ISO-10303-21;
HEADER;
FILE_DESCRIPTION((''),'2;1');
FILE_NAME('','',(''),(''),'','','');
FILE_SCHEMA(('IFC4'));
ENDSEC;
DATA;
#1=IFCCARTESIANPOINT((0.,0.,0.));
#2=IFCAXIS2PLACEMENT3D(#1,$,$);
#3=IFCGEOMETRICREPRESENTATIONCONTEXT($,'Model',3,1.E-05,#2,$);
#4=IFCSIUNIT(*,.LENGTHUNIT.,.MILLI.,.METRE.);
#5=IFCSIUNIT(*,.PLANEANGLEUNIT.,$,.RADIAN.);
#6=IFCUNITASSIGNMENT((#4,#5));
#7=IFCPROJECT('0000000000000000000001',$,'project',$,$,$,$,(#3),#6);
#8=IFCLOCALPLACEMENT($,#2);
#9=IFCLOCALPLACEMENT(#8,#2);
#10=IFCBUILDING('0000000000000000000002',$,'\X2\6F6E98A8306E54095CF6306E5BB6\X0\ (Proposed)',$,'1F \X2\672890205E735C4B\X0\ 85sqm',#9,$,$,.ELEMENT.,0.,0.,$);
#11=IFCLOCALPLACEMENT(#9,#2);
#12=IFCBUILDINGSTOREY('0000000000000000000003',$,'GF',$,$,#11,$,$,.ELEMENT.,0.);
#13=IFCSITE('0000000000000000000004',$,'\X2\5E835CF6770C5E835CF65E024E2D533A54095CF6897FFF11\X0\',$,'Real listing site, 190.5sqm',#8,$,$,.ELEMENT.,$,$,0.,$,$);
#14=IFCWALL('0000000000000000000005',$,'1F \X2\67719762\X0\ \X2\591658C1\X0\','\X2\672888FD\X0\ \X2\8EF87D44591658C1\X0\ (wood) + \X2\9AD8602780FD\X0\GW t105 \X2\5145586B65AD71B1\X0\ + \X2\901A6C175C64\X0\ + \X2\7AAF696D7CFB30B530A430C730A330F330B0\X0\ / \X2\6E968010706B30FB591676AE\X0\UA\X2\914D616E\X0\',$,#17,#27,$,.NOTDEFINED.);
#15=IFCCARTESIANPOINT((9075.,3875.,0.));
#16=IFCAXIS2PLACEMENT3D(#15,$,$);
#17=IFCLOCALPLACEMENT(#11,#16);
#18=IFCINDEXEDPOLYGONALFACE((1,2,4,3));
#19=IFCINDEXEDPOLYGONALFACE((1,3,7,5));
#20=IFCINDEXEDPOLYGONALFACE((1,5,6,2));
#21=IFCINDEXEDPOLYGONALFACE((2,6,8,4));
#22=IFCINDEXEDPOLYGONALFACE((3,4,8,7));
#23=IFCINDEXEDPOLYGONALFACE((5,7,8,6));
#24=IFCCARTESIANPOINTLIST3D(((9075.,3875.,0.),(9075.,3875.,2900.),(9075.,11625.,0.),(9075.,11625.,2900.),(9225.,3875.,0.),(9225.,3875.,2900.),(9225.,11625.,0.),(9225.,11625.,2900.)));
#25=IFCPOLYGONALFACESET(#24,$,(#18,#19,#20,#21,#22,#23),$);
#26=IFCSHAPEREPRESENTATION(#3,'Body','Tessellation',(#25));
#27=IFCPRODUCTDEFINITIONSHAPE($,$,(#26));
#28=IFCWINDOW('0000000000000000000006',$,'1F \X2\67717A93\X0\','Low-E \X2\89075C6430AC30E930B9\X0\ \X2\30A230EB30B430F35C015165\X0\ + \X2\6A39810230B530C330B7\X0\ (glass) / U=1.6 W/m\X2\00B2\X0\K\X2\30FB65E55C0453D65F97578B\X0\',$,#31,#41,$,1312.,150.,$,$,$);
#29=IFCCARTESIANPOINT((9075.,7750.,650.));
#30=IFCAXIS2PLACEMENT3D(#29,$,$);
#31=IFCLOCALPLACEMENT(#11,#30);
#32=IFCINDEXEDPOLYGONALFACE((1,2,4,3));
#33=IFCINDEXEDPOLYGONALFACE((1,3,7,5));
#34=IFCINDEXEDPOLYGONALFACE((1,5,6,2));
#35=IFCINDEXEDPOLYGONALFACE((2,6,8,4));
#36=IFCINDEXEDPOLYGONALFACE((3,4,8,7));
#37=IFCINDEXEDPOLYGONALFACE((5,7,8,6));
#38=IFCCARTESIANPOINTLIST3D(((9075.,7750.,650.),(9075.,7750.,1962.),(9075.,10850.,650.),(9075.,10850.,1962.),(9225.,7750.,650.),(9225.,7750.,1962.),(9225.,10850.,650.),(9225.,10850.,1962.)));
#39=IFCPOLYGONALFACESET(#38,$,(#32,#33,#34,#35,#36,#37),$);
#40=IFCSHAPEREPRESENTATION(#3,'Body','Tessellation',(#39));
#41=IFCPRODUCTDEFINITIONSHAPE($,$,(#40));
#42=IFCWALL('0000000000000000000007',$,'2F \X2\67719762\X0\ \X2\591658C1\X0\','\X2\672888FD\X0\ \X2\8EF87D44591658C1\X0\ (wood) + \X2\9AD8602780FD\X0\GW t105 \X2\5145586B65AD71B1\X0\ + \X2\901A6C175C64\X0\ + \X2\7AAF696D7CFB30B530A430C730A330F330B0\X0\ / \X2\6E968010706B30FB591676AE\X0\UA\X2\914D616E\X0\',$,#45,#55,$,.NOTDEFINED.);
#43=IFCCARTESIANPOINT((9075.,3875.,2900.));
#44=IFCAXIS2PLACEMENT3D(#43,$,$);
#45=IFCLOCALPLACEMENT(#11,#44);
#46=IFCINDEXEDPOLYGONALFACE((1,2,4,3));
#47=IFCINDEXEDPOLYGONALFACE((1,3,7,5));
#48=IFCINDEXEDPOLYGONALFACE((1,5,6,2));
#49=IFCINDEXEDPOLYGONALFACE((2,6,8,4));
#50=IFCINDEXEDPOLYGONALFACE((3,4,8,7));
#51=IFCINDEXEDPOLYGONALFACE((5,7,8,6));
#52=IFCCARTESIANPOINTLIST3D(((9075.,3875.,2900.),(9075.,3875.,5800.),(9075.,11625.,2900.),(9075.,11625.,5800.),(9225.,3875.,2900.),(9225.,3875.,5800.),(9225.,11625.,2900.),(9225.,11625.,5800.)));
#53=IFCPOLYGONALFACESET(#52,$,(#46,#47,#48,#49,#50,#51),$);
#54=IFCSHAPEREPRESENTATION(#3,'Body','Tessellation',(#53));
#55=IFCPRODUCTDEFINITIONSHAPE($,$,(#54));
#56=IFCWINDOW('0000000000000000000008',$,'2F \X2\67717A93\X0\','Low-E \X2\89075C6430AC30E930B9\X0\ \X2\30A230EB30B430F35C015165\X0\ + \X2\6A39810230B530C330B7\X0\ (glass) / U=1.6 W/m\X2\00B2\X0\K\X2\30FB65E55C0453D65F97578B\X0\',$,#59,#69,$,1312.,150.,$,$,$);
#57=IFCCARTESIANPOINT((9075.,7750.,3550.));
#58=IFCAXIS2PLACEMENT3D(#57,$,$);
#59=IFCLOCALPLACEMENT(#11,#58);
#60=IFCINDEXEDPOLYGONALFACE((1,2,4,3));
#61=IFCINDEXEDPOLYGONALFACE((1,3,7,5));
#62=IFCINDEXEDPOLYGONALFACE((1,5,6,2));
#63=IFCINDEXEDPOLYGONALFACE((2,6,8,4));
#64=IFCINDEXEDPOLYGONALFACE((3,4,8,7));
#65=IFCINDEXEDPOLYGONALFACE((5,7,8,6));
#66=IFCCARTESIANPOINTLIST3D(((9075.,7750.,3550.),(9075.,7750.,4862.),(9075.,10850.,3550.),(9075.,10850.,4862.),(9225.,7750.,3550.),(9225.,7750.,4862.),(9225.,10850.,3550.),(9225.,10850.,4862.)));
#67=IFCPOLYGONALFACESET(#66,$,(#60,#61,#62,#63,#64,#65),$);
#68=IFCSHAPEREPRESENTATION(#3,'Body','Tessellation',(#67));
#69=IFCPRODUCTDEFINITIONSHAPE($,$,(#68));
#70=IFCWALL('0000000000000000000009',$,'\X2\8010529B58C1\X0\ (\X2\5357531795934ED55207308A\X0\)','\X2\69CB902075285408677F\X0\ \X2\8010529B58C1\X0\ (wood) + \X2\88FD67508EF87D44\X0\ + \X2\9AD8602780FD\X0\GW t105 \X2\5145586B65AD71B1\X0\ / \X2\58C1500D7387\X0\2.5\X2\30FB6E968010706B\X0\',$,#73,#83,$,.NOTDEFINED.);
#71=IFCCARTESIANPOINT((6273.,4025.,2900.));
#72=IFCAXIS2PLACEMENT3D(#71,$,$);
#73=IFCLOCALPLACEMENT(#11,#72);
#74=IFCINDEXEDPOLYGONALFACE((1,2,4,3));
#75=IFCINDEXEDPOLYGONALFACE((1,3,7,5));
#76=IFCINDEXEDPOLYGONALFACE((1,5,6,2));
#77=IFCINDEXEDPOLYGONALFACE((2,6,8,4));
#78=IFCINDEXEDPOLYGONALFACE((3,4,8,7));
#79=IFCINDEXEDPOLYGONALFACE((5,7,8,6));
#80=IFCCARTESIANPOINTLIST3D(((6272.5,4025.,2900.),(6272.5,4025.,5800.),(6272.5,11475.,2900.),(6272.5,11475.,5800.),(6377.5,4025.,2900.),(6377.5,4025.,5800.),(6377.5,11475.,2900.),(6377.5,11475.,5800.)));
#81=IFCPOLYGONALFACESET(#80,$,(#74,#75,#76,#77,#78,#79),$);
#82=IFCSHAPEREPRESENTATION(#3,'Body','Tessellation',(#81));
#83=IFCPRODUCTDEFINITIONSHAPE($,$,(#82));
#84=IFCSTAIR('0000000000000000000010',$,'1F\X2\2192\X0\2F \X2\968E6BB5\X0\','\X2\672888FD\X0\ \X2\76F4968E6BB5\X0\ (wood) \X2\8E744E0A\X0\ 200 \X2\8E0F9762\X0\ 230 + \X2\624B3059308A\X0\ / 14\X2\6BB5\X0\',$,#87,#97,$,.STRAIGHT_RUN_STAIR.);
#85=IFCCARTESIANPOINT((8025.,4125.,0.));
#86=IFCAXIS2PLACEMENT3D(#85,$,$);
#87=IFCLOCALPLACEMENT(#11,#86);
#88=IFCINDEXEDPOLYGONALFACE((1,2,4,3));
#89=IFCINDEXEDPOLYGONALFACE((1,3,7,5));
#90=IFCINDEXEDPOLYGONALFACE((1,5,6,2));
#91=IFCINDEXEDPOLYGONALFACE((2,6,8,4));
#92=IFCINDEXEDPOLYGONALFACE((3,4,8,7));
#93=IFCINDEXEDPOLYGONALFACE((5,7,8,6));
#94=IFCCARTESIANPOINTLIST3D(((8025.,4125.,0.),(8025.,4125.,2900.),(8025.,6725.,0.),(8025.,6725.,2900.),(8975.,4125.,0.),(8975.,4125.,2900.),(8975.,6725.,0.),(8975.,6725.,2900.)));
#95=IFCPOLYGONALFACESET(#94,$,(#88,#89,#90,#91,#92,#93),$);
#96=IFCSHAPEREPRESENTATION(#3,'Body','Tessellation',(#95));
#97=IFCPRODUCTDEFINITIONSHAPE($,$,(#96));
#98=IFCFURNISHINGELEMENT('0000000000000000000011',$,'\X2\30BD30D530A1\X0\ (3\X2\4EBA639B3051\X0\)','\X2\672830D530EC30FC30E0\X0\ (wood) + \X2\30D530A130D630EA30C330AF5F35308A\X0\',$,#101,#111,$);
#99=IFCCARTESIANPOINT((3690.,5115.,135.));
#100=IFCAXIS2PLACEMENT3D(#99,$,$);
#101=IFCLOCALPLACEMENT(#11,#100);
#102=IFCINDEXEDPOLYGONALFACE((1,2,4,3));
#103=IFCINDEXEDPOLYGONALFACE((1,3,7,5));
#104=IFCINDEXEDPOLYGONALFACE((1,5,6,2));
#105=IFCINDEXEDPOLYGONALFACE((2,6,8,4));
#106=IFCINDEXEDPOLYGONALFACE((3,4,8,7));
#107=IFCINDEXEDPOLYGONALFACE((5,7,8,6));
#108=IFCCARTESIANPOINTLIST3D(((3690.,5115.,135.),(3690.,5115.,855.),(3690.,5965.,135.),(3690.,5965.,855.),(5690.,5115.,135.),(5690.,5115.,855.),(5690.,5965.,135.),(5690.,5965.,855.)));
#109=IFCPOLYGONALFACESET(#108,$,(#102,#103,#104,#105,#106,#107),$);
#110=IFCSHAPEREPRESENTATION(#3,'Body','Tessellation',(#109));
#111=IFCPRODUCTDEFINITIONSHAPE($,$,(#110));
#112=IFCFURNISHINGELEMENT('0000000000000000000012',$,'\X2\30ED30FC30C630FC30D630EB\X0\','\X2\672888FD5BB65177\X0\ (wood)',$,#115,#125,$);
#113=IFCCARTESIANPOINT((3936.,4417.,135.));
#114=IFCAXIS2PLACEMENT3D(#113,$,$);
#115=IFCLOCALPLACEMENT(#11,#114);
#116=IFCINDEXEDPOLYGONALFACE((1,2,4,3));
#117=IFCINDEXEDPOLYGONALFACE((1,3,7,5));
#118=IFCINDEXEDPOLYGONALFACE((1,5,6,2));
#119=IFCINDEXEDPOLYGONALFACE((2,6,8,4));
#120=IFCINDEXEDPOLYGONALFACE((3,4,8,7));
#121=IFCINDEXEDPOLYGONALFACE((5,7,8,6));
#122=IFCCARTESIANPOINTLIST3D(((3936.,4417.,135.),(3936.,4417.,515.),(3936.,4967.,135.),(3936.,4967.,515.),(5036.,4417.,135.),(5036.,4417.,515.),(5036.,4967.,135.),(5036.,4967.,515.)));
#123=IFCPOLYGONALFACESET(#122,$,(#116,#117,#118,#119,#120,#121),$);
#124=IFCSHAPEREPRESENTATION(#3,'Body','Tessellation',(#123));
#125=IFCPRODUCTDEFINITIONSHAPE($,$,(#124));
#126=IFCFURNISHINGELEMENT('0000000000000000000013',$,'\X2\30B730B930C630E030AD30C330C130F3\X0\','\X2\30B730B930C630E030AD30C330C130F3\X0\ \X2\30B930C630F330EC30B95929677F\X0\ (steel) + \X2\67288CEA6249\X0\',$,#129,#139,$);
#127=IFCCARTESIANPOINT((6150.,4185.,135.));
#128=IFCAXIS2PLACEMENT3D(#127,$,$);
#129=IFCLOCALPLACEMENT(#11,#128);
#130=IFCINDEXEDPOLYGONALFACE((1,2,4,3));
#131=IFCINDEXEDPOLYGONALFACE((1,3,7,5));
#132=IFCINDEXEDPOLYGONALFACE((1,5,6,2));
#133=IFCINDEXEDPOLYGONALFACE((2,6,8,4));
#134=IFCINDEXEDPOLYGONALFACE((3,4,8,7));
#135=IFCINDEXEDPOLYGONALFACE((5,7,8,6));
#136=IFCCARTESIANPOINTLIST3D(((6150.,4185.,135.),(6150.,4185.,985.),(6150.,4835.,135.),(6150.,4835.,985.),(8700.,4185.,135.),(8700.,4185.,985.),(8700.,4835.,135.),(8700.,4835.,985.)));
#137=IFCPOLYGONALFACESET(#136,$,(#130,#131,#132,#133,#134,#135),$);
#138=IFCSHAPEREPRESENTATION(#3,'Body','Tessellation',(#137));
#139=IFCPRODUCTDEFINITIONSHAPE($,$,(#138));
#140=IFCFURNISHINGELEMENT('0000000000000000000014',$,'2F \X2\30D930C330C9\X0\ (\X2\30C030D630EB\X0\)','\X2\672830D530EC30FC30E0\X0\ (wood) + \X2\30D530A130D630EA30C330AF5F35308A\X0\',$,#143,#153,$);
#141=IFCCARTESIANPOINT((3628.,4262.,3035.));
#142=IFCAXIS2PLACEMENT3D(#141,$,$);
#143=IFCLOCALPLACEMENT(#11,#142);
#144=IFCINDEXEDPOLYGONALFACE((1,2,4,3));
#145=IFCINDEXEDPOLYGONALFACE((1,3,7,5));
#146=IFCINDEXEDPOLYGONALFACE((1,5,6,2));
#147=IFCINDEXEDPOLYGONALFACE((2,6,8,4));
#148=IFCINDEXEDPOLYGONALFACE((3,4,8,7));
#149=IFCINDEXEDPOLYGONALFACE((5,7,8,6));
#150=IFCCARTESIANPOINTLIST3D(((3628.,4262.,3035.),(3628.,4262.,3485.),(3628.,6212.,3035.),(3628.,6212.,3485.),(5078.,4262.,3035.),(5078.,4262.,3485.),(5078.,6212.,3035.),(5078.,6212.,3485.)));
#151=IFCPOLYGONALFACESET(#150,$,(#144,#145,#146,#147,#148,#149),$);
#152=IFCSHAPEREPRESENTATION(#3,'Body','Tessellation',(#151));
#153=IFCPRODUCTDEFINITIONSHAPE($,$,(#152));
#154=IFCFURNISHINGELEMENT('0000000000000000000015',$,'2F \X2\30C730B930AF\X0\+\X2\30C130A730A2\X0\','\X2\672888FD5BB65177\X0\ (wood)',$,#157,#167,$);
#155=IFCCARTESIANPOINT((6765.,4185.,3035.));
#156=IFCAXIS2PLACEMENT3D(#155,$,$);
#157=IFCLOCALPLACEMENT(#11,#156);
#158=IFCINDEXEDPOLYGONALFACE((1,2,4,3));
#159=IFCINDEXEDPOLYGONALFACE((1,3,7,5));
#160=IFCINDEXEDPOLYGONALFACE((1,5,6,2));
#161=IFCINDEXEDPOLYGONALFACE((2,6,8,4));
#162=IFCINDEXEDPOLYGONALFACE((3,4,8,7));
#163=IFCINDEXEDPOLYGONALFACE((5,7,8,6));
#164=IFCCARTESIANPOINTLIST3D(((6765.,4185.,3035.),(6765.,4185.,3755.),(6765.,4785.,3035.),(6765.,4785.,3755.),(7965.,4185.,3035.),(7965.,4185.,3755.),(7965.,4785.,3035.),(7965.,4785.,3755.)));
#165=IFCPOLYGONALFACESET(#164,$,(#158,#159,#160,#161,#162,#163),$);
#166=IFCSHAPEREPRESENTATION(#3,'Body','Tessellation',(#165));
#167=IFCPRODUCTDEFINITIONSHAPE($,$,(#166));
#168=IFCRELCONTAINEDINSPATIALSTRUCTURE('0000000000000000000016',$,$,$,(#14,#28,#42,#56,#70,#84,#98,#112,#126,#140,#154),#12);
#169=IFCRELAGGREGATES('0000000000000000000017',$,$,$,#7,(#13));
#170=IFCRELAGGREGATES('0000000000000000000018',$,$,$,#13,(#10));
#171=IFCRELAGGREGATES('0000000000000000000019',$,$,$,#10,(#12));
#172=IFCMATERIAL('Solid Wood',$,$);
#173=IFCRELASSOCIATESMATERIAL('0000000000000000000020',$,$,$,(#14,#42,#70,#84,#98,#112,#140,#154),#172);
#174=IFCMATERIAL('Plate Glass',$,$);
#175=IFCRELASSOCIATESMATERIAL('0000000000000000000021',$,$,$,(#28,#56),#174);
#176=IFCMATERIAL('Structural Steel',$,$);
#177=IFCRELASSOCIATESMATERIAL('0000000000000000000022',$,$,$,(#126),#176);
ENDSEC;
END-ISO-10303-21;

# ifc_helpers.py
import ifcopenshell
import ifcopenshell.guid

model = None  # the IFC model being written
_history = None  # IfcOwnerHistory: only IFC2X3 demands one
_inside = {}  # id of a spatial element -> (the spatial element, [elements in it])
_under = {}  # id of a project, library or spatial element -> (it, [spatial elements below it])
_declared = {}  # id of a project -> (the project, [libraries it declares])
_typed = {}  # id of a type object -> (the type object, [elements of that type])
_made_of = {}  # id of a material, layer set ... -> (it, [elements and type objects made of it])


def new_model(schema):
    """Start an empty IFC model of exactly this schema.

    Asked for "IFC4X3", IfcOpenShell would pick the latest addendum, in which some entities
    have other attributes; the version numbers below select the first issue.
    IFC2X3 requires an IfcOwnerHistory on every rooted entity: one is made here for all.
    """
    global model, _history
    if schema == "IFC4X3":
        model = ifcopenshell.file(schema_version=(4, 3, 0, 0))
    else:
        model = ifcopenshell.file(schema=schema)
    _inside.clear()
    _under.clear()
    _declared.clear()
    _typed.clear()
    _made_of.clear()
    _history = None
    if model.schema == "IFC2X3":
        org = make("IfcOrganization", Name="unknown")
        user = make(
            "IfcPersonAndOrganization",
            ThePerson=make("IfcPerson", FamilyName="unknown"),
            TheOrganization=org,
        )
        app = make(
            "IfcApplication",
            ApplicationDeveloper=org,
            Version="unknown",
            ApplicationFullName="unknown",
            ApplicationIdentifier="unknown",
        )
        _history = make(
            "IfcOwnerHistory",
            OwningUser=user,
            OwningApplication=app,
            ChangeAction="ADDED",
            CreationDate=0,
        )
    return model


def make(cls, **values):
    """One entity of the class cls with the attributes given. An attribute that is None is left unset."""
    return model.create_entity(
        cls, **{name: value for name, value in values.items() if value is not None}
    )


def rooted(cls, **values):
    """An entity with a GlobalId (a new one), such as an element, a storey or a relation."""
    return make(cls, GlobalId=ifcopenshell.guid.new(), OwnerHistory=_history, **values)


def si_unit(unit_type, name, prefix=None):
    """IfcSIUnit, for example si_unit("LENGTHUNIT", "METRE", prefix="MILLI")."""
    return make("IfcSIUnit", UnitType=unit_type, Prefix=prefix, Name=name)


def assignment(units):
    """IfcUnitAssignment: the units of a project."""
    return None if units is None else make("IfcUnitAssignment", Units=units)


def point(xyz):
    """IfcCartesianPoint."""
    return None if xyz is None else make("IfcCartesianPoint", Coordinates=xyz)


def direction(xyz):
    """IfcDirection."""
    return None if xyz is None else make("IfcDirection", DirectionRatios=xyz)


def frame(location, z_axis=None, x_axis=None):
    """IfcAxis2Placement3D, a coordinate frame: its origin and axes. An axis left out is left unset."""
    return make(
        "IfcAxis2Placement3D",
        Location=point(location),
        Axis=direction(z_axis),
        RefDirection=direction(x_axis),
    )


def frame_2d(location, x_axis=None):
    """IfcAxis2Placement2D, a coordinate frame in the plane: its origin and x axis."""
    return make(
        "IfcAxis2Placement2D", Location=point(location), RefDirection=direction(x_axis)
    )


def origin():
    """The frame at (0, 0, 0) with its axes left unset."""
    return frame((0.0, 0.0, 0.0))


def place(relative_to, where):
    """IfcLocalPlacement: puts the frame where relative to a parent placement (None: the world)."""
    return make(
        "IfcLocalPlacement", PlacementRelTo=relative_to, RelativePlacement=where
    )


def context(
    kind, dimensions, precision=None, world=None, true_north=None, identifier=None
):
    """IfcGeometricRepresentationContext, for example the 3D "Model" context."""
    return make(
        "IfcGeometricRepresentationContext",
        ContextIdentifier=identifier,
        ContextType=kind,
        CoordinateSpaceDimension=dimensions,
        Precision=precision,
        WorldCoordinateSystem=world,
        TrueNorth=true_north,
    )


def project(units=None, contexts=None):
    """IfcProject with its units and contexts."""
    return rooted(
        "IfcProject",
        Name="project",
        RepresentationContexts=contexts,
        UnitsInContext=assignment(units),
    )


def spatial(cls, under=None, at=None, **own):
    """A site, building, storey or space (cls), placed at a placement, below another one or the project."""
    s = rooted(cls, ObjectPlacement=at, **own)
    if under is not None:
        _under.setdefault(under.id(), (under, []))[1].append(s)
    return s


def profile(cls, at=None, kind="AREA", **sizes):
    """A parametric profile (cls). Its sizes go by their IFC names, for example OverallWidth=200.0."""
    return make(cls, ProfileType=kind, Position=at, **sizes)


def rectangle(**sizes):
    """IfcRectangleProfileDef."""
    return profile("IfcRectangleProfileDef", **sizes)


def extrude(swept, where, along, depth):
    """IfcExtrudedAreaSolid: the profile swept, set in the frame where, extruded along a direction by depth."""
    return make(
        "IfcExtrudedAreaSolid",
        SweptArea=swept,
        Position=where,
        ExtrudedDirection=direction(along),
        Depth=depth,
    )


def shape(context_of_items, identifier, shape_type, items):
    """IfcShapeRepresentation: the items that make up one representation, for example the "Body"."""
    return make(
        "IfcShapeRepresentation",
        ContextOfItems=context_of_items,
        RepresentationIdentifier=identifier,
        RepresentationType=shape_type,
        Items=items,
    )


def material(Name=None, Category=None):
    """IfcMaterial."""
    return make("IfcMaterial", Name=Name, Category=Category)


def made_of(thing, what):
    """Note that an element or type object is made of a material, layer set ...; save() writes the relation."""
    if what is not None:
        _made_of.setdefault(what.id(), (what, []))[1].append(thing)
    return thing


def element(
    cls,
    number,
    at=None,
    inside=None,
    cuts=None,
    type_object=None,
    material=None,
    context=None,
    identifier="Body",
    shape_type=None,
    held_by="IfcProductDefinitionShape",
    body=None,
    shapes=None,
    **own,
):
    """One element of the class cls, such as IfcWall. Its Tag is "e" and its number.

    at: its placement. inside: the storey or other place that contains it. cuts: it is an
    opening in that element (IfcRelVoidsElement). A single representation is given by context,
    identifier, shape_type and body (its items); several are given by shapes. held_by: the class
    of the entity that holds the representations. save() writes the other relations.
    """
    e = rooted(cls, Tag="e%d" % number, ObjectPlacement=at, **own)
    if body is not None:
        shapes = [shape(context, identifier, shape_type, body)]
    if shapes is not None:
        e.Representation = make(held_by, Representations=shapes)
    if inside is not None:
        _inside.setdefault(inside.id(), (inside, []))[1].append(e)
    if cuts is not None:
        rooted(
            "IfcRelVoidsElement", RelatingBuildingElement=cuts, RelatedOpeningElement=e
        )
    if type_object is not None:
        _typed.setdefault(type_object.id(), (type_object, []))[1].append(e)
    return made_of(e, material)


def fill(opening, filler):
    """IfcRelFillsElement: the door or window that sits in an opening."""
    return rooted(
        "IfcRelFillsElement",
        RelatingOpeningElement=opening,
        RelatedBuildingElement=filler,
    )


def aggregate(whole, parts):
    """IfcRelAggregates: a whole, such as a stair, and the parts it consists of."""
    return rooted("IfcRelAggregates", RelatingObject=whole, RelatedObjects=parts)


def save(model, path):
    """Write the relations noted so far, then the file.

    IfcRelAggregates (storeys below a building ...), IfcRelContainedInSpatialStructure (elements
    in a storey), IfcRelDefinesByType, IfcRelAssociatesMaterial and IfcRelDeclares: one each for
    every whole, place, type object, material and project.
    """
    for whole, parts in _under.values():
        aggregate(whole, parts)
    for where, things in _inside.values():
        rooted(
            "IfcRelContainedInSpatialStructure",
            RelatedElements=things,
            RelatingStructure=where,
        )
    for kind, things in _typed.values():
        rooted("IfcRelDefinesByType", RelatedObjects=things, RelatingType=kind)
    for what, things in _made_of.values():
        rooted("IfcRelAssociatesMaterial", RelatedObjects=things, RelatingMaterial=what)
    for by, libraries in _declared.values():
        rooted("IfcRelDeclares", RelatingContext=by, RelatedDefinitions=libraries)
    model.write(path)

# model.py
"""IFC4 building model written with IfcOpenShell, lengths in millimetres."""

from ifc_helpers import new_model, si_unit, frame, frame_2d, origin, place, context, project, spatial, rectangle, extrude, material, element, fill, save


model = new_model("IFC4")

# Units and contexts
model_context = context("Model", 3, precision=1e-05, world=origin())
ifc_project = project(units=[si_unit("LENGTHUNIT", "METRE", prefix="MILLI"), si_unit("PLANEANGLEUNIT", "RADIAN")], contexts=[model_context])

# Site, building, storey
site_placement = place(None, origin())
site = spatial("IfcSite", under=ifc_project, at=site_placement, Name="広島県広島市中区吉島西１", ObjectType="Real listing site, 190.5sqm", CompositionType="ELEMENT", RefElevation=0.0)
building_placement = place(site_placement, origin())
building = spatial("IfcBuilding", under=site, at=building_placement, Name="潮風の吉島の家 (Proposed)", ObjectType="1F 木造平屋 85sqm", CompositionType="ELEMENT", ElevationOfRefHeight=0.0, ElevationOfTerrain=0.0)
storey_placement = place(building_placement, origin())
storey = spatial("IfcBuildingStorey", under=building, at=storey_placement, Name="GF", CompositionType="ELEMENT", Elevation=0.0)

# Wall, opening, window
ifc_material_1 = material(Name="Solid Wood")
wall_1_placement = place(storey_placement, frame((9075.0, 3875.0, 0.0)))
wall_1 = element("IfcWall", 1, at=wall_1_placement, inside=storey, material=ifc_material_1, Name="1F 東面 外壁", Description="木製 軸組外壁 (wood) + 高性能GW t105 充填断熱 + 通気層 + 窯業系サイディング / 準耐火・外皮UA配慮", PredefinedType="NOTDEFINED", context=model_context, shape_type="SweptSolid", body=[
    extrude(rectangle(XDim=150.0, YDim=7750.0, at=frame_2d((75.0, 3875.0))), frame((9075.0, 3875.0, 0.0)), (0.0, 0.0, 1.0), 2900.0),
])
opening_1_placement = place(storey_placement, frame((9075.0, 7750.0, 650.0)))
opening_1 = element("IfcOpeningElement", 2, at=opening_1_placement, cuts=wall_1, PredefinedType="NOTDEFINED", context=model_context, shape_type="SweptSolid", body=[
    extrude(rectangle(XDim=150.0, YDim=3100.0, at=frame_2d((75.0, 1550.0))), frame((9075.0, 7750.0, 650.0)), (0.0, 0.0, 1.0), 1312.0),
])
ifc_material_2 = material(Name="Plate Glass")
window_1_placement = place(storey_placement, frame((9075.0, 7750.0, 650.0)))
window_1 = element("IfcWindow", 3, at=window_1_placement, inside=storey, material=ifc_material_2, Name="1F 東窓", Description="Low-E 複層ガラス アルゴン封入 + 樹脂サッシ (glass) / U=1.6 W/m²K・日射取得型", OverallHeight=1312.0, OverallWidth=150.0, context=model_context, shape_type="SweptSolid", body=[
    extrude(rectangle(XDim=150.0, YDim=3100.0, at=frame_2d((75.0, 1550.0))), frame((9075.0, 7750.0, 650.0)), (0.0, 0.0, 1.0), 1312.0),
])
fill(opening_1, window_1)

# Wall, opening, window
wall_2_placement = place(storey_placement, frame((9075.0, 3875.0, 2900.0)))
wall_2 = element("IfcWall", 4, at=wall_2_placement, inside=storey, material=ifc_material_1, Name="2F 東面 外壁", Description="木製 軸組外壁 (wood) + 高性能GW t105 充填断熱 + 通気層 + 窯業系サイディング / 準耐火・外皮UA配慮", PredefinedType="NOTDEFINED", context=model_context, shape_type="SweptSolid", body=[
    extrude(rectangle(XDim=150.0, YDim=7750.0, at=frame_2d((75.0, 3875.0))), frame((9075.0, 3875.0, 2900.0)), (0.0, 0.0, 1.0), 2900.0),
])
opening_2_placement = place(storey_placement, frame((9075.0, 7750.0, 3550.0)))
opening_2 = element("IfcOpeningElement", 5, at=opening_2_placement, cuts=wall_2, PredefinedType="NOTDEFINED", context=model_context, shape_type="SweptSolid", body=[
    extrude(rectangle(XDim=150.0, YDim=3100.0, at=frame_2d((75.0, 1550.0))), frame((9075.0, 7750.0, 3550.0)), (0.0, 0.0, 1.0), 1312.0),
])
window_2_placement = place(storey_placement, frame((9075.0, 7750.0, 3550.0)))
window_2 = element("IfcWindow", 6, at=window_2_placement, inside=storey, material=ifc_material_2, Name="2F 東窓", Description="Low-E 複層ガラス アルゴン封入 + 樹脂サッシ (glass) / U=1.6 W/m²K・日射取得型", OverallHeight=1312.0, OverallWidth=150.0, context=model_context, shape_type="SweptSolid", body=[
    extrude(rectangle(XDim=150.0, YDim=3100.0, at=frame_2d((75.0, 1550.0))), frame((9075.0, 7750.0, 3550.0)), (0.0, 0.0, 1.0), 1312.0),
])
fill(opening_2, window_2)

# Wall
wall_3_placement = place(storey_placement, frame((6273.0, 4025.0, 2900.0)))
element("IfcWall", 7, at=wall_3_placement, inside=storey, material=ifc_material_1, Name="耐力壁 (南北間仕切り)", Description="構造用合板 耐力壁 (wood) + 製材軸組 + 高性能GW t105 充填断熱 / 壁倍率2.5・準耐火", PredefinedType="NOTDEFINED", context=model_context, shape_type="SweptSolid", body=[
    extrude(rectangle(XDim=105.0, YDim=7450.0, at=frame_2d((52.0, 3725.0))), frame((6273.0, 4025.0, 2900.0)), (0.0, 0.0, 1.0), 2900.0),
])

# Stair
stair_placement = place(storey_placement, frame((8025.0, 4125.0, 0.0)))
element("IfcStair", 8, at=stair_placement, inside=storey, material=ifc_material_1, Name="1F→2F 階段", Description="木製 直階段 (wood) 蹴上 200 踏面 230 + 手すり / 14段", PredefinedType="STRAIGHT_RUN_STAIR", context=model_context, shape_type="SweptSolid", body=[
    extrude(rectangle(XDim=950.0, YDim=2600.0, at=frame_2d((475.0, 1300.0))), frame((8025.0, 4125.0, 0.0)), (0.0, 0.0, 1.0), 2900.0),
])

# Furnishing elements
furnishing_1_placement = place(storey_placement, frame((3690.0, 5115.0, 135.0)))
element("IfcFurnishingElement", 9, at=furnishing_1_placement, inside=storey, material=ifc_material_1, Name="ソファ (3人掛け)", Description="木フレーム (wood) + ファブリック張り", context=model_context, shape_type="SweptSolid", body=[
    extrude(rectangle(XDim=2000.0, YDim=850.0, at=frame_2d((1000.0, 425.0))), frame((3690.0, 5115.0, 135.0)), (0.0, 0.0, 1.0), 720.0),
])
furnishing_2_placement = place(storey_placement, frame((3936.0, 4417.0, 135.0)))
element("IfcFurnishingElement", 10, at=furnishing_2_placement, inside=storey, material=ifc_material_1, Name="ローテーブル", Description="木製家具 (wood)", context=model_context, shape_type="SweptSolid", body=[
    extrude(rectangle(XDim=1100.0, YDim=550.0, at=frame_2d((550.0, 275.0))), frame((3936.0, 4417.0, 135.0)), (0.0, 0.0, 1.0), 380.0),
])
ifc_material_3 = material(Name="Structural Steel")
furnishing_3_placement = place(storey_placement, frame((6150.0, 4185.0, 135.0)))
element("IfcFurnishingElement", 11, at=furnishing_3_placement, inside=storey, material=ifc_material_3, Name="システムキッチン", Description="システムキッチン ステンレス天板 (steel) + 木質扉", context=model_context, shape_type="SweptSolid", body=[
    extrude(rectangle(XDim=2550.0, YDim=650.0, at=frame_2d((1275.0, 325.0))), frame((6150.0, 4185.0, 135.0)), (0.0, 0.0, 1.0), 850.0),
])
furnishing_4_placement = place(storey_placement, frame((3628.0, 4262.0, 3035.0)))
element("IfcFurnishingElement", 12, at=furnishing_4_placement, inside=storey, material=ifc_material_1, Name="2F ベッド (ダブル)", Description="木フレーム (wood) + ファブリック張り", context=model_context, shape_type="SweptSolid", body=[
    extrude(rectangle(XDim=1450.0, YDim=1950.0, at=frame_2d((725.0, 975.0))), frame((3628.0, 4262.0, 3035.0)), (0.0, 0.0, 1.0), 450.0),
])
furnishing_5_placement = place(storey_placement, frame((6765.0, 4185.0, 3035.0)))
element("IfcFurnishingElement", 13, at=furnishing_5_placement, inside=storey, material=ifc_material_1, Name="2F デスク+チェア", Description="木製家具 (wood)", context=model_context, shape_type="SweptSolid", body=[
    extrude(rectangle(XDim=1200.0, YDim=600.0, at=frame_2d((600.0, 300.0))), frame((6765.0, 4185.0, 3035.0)), (0.0, 0.0, 1.0), 720.0),
])

save(model, "model.ifc")
